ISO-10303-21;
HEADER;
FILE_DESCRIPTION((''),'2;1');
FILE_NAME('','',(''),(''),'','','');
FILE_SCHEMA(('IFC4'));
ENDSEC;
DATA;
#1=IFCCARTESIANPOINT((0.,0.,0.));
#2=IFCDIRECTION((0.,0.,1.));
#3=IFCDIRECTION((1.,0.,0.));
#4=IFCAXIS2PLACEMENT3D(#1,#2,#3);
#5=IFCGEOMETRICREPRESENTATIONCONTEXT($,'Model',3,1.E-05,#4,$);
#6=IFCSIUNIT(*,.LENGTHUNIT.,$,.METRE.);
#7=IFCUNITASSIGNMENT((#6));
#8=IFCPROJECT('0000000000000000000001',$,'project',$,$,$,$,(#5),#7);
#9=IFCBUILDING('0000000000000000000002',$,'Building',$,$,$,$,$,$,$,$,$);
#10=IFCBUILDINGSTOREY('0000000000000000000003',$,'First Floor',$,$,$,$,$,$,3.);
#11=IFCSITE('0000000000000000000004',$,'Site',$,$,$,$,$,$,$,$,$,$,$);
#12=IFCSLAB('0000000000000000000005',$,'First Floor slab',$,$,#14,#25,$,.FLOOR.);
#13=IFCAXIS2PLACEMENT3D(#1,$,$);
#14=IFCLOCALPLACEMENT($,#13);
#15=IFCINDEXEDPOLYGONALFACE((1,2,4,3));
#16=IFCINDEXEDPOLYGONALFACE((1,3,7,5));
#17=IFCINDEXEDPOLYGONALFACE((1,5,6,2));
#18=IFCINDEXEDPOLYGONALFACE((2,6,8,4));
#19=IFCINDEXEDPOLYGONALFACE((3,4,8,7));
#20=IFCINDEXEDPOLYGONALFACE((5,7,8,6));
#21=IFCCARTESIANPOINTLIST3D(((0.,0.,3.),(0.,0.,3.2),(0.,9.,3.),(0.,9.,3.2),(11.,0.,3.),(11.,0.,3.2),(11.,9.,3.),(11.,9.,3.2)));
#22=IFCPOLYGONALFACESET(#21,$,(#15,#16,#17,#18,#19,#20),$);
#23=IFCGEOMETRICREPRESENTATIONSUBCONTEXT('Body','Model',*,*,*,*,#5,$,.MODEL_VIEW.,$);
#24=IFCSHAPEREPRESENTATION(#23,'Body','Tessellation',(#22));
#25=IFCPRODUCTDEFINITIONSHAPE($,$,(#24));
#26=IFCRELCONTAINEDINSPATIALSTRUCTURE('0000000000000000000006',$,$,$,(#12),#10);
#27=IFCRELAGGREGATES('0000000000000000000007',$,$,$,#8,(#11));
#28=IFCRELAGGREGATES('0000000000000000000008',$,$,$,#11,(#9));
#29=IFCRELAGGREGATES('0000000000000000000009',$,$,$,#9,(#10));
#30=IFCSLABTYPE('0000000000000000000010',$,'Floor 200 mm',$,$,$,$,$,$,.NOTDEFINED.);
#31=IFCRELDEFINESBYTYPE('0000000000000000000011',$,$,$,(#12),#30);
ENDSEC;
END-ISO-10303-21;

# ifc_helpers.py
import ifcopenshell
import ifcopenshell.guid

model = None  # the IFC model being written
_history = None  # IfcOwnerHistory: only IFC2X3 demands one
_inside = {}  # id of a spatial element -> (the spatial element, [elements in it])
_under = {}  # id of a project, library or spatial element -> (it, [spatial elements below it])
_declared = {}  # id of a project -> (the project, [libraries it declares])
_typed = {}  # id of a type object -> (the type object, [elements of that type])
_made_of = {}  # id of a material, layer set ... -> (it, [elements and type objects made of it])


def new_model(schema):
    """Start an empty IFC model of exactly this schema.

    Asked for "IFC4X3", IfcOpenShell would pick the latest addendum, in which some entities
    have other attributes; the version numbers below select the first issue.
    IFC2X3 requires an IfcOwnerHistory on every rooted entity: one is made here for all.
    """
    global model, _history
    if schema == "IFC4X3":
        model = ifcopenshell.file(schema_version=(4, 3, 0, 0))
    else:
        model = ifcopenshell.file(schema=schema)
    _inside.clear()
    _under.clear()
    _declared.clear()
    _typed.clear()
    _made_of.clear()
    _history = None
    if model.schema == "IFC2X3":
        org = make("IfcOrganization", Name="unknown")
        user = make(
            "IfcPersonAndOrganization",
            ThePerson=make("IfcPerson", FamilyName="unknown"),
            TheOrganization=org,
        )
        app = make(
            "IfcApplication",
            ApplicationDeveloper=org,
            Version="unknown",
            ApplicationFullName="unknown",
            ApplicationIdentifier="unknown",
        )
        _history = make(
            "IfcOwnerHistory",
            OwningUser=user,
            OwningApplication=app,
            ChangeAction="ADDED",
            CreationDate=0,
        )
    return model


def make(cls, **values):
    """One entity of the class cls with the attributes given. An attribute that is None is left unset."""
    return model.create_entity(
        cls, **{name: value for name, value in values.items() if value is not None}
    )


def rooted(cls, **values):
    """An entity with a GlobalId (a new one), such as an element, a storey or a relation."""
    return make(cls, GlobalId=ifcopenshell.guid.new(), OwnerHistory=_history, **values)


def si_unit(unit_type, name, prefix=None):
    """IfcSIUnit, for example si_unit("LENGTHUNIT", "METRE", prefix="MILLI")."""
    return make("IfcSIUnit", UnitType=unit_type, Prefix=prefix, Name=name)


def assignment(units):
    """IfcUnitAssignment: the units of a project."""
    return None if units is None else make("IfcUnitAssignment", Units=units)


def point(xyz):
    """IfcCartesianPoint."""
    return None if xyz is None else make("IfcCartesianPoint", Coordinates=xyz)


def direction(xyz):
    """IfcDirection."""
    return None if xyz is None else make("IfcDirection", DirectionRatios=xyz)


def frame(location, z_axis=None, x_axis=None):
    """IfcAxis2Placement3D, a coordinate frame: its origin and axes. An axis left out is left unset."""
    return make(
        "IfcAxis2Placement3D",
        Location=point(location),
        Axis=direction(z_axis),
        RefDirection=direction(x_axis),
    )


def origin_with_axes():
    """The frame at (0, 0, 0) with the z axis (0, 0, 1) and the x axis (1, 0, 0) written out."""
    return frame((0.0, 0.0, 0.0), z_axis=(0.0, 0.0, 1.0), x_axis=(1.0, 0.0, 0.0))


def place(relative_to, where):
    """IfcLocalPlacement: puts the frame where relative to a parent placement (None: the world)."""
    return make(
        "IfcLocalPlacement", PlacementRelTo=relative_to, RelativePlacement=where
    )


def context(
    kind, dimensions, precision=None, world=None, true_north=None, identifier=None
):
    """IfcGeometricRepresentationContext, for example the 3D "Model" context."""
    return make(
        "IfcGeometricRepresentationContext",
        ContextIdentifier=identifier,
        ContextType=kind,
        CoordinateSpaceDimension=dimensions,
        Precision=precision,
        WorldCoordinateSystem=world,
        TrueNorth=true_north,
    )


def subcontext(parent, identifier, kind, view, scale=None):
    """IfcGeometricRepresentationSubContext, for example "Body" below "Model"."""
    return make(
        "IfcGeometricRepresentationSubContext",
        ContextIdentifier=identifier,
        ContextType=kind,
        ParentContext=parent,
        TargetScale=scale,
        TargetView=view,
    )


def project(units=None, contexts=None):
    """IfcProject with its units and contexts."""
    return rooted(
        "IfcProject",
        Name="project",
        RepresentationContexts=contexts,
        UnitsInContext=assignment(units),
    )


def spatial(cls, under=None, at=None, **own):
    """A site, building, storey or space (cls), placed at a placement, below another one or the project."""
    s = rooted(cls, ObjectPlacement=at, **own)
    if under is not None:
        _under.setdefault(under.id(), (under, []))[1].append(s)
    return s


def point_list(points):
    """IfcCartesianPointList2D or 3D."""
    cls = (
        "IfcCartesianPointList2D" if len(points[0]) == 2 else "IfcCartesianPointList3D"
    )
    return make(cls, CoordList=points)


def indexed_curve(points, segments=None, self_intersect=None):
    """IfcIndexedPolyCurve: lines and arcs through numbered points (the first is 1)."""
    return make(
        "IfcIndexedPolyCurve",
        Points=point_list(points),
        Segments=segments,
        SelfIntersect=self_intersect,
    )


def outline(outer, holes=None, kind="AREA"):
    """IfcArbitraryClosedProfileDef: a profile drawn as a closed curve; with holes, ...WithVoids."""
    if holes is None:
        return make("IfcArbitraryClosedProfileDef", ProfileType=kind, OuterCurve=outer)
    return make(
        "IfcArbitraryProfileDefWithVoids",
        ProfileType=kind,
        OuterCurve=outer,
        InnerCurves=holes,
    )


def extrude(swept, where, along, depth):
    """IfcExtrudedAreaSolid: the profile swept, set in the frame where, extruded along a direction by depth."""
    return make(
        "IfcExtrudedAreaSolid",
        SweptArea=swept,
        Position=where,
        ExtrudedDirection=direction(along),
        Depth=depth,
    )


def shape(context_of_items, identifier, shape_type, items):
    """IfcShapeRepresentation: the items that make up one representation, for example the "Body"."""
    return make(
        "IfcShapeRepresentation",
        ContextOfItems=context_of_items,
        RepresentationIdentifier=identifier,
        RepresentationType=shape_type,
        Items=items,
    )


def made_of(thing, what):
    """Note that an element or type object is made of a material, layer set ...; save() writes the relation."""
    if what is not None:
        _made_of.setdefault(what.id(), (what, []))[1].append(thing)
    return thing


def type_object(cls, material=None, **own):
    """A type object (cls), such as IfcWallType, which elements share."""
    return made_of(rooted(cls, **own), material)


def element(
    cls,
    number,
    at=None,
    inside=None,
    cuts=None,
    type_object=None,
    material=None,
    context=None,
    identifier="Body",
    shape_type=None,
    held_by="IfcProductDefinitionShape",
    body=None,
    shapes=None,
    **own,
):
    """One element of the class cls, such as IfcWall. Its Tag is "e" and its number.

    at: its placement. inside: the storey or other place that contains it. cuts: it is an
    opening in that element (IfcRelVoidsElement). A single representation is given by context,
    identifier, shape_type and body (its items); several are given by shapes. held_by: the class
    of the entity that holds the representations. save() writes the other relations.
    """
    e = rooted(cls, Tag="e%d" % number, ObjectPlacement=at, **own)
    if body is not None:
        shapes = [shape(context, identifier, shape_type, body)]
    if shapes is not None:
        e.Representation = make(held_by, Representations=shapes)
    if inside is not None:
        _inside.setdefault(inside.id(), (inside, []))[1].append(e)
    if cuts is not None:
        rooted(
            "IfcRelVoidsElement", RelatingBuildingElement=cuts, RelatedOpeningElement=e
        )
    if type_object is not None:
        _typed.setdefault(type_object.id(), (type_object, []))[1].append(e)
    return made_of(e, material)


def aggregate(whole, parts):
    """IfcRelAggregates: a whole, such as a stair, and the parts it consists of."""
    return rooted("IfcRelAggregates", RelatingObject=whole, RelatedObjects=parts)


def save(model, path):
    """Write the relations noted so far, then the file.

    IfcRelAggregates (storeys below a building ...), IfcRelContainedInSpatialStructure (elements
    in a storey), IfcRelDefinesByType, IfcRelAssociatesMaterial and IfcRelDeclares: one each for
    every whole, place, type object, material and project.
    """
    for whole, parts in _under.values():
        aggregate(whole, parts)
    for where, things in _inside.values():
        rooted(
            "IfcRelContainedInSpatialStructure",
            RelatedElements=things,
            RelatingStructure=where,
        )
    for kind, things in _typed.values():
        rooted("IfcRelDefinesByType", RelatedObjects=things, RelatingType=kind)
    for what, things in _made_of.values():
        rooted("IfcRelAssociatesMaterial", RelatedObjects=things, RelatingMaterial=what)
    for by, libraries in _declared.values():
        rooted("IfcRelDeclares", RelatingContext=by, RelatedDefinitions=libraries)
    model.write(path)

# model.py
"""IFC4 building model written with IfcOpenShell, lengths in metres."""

from ifc_helpers import new_model, si_unit, frame, origin_with_axes, place, context, subcontext, project, spatial, indexed_curve, outline, extrude, type_object, element, save


model = new_model("IFC4")

# Units and contexts
model_context = context("Model", 3, precision=1e-05, world=origin_with_axes())
body_context = subcontext(model_context, "Body", "Model", "MODEL_VIEW")
ifc_project = project(units=[si_unit("LENGTHUNIT", "METRE")], contexts=[model_context])

# Site, building, storey
site = spatial("IfcSite", under=ifc_project, Name="Site")
building = spatial("IfcBuilding", under=site, Name="Building")
storey = spatial("IfcBuildingStorey", under=building, Name="First Floor", Elevation=3.0)

# Slab
slab_type = type_object("IfcSlabType", Name="Floor 200 mm", PredefinedType="NOTDEFINED")
slab_placement = place(None, frame((0.0, 0.0, 3.0), z_axis=(0.0, 0.0, 1.0), x_axis=(1.0, 0.0, 0.0)))
element("IfcSlab", 1, at=slab_placement, inside=storey, type_object=slab_type, Name="First Floor slab", PredefinedType="FLOOR", context=body_context, shape_type="SweptSolid", body=[
    extrude(outline(indexed_curve([(0.0, 0.0), (11.0, 0.0), (11.0, 9.0), (0.0, 9.0)])), None, (0.0, 0.0, 1.0), 0.2),
])

save(model, "model.ifc")
